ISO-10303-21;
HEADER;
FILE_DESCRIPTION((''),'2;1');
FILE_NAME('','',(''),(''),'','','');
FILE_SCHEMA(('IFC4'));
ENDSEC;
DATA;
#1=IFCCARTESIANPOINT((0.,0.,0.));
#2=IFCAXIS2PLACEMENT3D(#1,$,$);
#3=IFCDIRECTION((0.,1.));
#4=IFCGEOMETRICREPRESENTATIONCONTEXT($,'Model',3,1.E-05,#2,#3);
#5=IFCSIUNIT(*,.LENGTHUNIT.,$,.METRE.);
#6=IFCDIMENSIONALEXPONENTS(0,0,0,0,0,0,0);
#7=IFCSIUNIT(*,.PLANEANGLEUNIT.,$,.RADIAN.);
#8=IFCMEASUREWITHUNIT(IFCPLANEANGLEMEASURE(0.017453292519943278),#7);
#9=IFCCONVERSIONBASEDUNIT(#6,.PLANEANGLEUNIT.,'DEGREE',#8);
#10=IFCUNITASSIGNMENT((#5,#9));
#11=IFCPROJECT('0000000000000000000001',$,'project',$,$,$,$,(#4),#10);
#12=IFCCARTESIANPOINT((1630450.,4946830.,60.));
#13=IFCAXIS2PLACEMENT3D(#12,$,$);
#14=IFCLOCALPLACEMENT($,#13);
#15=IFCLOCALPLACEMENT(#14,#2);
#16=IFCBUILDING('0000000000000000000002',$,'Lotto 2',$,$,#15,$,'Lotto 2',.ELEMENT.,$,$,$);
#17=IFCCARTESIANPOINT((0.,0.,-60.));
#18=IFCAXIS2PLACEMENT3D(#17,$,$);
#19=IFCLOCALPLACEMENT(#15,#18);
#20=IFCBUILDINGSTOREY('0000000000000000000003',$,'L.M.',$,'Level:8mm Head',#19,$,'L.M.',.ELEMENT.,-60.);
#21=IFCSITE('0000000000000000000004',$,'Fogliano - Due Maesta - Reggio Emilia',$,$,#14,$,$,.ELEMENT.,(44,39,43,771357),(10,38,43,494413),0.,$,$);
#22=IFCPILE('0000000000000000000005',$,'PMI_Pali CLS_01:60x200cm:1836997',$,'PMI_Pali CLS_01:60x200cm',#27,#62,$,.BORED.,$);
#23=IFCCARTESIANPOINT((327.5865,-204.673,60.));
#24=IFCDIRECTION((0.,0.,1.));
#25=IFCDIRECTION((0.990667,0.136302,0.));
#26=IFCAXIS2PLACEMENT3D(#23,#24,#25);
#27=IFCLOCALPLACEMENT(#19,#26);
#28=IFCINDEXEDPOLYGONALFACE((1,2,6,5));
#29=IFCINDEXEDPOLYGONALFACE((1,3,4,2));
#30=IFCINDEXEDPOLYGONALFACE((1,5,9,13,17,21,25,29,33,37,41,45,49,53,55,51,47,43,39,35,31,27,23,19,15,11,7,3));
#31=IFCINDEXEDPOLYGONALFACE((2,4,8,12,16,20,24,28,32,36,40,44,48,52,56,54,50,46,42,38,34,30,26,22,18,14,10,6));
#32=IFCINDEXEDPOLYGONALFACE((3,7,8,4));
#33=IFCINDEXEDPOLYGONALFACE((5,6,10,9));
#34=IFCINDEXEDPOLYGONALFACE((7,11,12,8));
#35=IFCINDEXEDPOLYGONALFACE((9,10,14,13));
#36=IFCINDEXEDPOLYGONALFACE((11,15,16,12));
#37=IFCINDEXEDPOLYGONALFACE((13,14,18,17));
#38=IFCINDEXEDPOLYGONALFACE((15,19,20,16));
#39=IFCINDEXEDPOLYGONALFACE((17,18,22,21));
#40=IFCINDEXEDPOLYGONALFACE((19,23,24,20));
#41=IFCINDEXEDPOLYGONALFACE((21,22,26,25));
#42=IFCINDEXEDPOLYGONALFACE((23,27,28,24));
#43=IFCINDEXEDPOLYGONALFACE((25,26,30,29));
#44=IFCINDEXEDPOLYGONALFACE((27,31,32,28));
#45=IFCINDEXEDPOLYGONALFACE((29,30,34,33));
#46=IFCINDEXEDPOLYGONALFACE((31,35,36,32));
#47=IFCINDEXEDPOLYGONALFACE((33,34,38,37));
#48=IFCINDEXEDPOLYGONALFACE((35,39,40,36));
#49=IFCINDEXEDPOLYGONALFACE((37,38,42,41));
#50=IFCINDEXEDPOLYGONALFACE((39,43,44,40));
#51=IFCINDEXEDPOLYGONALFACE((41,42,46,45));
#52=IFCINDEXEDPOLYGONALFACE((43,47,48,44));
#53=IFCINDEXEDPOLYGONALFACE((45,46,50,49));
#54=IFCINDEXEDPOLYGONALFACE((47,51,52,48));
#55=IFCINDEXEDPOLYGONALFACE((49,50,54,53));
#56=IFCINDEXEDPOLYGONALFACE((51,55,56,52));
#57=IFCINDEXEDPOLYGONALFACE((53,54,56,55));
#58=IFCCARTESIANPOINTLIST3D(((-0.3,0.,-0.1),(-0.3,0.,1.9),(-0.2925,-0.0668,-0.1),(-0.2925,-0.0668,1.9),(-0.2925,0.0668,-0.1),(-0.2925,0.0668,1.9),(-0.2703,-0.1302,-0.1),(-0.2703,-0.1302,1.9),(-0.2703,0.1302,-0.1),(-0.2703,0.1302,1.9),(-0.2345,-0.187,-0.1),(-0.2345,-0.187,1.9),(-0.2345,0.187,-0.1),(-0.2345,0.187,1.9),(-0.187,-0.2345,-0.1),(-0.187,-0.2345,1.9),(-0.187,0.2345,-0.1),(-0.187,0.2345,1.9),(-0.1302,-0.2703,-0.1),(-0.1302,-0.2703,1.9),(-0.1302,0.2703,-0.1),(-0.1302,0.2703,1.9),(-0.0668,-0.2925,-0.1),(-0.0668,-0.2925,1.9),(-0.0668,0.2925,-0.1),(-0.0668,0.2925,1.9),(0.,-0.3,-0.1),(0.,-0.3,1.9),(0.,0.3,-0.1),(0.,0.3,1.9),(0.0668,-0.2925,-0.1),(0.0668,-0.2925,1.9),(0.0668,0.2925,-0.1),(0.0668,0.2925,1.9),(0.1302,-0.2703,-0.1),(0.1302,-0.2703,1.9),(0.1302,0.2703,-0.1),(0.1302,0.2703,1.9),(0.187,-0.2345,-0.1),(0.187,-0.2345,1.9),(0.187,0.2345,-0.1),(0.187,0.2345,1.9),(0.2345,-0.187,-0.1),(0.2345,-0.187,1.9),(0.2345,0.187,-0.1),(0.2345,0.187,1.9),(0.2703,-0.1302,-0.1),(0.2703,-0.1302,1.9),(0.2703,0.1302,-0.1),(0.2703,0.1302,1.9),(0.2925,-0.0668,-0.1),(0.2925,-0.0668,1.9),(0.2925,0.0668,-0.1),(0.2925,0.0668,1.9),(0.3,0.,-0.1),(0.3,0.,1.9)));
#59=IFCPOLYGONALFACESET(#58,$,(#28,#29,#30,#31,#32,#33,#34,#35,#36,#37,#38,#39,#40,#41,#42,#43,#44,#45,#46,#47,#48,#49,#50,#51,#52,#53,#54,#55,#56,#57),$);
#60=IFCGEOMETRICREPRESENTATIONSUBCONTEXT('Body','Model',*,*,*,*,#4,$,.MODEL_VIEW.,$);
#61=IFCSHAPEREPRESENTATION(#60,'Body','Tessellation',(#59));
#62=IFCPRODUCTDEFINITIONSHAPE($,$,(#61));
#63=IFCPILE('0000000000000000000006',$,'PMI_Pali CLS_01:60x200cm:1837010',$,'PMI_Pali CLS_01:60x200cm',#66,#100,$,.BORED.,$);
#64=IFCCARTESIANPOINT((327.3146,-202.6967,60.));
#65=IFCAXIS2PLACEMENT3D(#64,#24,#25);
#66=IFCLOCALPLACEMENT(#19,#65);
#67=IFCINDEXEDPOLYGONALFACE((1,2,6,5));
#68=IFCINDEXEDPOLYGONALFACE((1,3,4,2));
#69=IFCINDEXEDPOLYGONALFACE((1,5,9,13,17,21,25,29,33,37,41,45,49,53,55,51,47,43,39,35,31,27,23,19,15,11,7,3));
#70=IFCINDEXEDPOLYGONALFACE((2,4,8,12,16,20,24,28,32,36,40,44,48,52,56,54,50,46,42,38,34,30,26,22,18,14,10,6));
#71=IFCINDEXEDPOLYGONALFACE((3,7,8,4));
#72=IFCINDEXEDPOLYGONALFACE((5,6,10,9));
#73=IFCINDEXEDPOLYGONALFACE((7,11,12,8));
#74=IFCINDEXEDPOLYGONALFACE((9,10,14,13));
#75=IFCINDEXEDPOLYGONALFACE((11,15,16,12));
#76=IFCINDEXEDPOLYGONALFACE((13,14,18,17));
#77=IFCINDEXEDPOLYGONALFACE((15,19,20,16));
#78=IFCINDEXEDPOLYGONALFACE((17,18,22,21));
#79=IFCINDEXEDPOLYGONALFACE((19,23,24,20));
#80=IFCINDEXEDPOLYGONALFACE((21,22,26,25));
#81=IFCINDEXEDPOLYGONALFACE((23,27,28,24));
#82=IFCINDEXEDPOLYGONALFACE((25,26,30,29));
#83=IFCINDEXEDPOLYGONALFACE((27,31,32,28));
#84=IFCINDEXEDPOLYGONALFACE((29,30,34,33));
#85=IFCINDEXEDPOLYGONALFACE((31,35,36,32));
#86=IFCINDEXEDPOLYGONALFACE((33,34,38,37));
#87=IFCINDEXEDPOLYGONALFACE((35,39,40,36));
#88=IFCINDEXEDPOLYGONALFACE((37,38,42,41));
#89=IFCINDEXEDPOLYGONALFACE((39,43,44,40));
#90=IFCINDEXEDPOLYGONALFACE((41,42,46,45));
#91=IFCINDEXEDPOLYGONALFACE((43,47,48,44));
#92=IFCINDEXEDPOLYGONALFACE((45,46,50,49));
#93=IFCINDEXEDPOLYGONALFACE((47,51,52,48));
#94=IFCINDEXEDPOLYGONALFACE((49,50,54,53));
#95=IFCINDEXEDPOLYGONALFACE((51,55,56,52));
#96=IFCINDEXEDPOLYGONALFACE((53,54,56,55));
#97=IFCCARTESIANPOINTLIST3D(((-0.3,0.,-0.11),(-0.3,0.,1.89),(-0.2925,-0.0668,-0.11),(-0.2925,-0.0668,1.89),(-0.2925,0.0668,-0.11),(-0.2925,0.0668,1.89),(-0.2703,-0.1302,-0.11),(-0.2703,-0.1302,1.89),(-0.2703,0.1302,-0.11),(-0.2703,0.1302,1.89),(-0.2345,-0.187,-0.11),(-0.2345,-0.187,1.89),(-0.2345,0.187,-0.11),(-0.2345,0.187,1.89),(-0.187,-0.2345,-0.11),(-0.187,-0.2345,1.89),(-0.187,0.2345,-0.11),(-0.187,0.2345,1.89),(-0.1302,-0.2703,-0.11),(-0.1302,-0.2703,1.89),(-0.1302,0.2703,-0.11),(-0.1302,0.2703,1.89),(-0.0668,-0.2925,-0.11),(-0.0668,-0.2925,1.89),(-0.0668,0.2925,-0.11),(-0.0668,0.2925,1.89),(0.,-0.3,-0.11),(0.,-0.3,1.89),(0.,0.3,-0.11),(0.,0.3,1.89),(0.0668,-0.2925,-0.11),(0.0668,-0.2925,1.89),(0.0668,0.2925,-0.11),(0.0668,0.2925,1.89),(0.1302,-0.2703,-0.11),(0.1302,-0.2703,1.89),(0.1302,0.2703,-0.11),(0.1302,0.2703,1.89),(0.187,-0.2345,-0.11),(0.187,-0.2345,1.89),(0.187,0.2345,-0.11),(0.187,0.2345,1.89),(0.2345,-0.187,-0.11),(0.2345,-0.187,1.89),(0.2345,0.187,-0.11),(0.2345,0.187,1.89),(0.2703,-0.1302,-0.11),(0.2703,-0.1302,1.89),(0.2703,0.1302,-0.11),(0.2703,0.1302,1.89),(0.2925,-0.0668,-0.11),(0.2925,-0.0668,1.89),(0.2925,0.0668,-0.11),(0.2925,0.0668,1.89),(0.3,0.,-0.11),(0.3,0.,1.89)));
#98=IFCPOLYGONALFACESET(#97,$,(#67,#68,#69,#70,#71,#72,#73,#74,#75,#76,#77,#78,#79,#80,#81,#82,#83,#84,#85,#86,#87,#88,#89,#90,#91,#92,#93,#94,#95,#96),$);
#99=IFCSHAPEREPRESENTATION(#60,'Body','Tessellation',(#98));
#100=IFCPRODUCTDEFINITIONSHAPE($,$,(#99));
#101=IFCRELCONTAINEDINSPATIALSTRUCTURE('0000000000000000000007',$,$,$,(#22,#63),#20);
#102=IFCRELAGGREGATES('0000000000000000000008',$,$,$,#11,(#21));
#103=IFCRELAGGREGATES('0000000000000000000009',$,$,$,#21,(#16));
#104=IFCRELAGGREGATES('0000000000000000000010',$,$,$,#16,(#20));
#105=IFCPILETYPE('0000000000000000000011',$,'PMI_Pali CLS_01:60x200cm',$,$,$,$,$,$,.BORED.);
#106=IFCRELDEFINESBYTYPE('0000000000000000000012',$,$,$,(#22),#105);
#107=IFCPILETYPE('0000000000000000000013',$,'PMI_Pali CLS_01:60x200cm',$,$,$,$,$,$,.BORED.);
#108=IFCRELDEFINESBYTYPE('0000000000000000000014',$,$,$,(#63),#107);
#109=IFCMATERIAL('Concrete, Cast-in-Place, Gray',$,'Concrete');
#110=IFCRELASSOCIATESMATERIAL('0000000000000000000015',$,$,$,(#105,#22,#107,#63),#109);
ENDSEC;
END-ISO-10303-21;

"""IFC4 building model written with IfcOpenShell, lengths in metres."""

from ifc_helpers import new_model, entity, si_unit, converted_unit, direction, frame, origin, place, context, subcontext, project, spatial, arc, indexed_curve, outline, extrude, source, transform, mapped, material, type_object, type_shapes, element, save


model = new_model("IFC4")

# Units and contexts
model_context = context("Model", 3, precision=1e-05, world=origin(), true_north=direction((0.0, 1.0)))
body_context = subcontext(model_context, "Body", "Model", "MODEL_VIEW")
ifc_project = project(units=[si_unit("LENGTHUNIT", "METRE"), converted_unit("PLANEANGLEUNIT", "DEGREE", entity("IfcPlaneAngleMeasure", 0.017453292519943278), si_unit("PLANEANGLEUNIT", "RADIAN"), dimensions=[0, 0, 0, 0, 0, 0, 0])], contexts=[model_context])

# Site, building, storey
site_placement = place(None, frame((1630450.0, 4946830.0, 60.0)))
site = spatial("IfcSite", under=ifc_project, at=site_placement, Name="Fogliano - Due Maesta - Reggio Emilia", CompositionType="ELEMENT", RefLatitude=(44, 39, 43, 771357), RefLongitude=(10, 38, 43, 494413), RefElevation=0.0)
building_placement = place(site_placement, origin())
building = spatial("IfcBuilding", under=site, at=building_placement, Name="Lotto 2", LongName="Lotto 2", CompositionType="ELEMENT")
storey_placement = place(building_placement, frame((0.0, 0.0, -60.0)))
storey = spatial("IfcBuildingStorey", under=building, at=storey_placement, Name="L.M.", ObjectType="Level:8mm Head", LongName="L.M.", CompositionType="ELEMENT", Elevation=-60.0)

# Piles
ifc_material_1 = material(Name="Concrete, Cast-in-Place, Gray", Category="Concrete")
pile_type_1 = type_object("IfcPileType", Name="PMI_Pali CLS_01:60x200cm", PredefinedType="BORED", material=ifc_material_1)
shared_shape_1 = source(origin(), body_context, "Body", "SweptSolid", [
    extrude(outline(indexed_curve([(-0.3, 0.0), (0.0, -0.3), (0.3, 0.0), (0.0, 0.3)], segments=[arc(1, 2, 3), arc(3, 4, 1)], self_intersect=False)), frame((0.0, 0.0, -0.1)), (0.0, 0.0, 1.0), 2.0),
])
type_shapes(pile_type_1, [shared_shape_1])
pile_1_placement = place(storey_placement, frame((327.5865, -204.673, 60.0), z_axis=(0.0, 0.0, 1.0), x_axis=(0.990667, 0.136302, 0.0)))
element("IfcPile", 1, at=pile_1_placement, inside=storey, type_object=pile_type_1, material=ifc_material_1, Name="PMI_Pali CLS_01:60x200cm:1836997", ObjectType="PMI_Pali CLS_01:60x200cm", PredefinedType="BORED", context=body_context, shape_type="MappedRepresentation", body=[
    mapped(shared_shape_1, transform((0.0, 0.0, 0.0), scale=1.0)),
])
pile_type_2 = type_object("IfcPileType", Name="PMI_Pali CLS_01:60x200cm", PredefinedType="BORED", material=ifc_material_1)
shared_shape_2 = source(origin(), body_context, "Body", "SweptSolid", [
    extrude(outline(indexed_curve([(-0.3, 0.0), (0.0, -0.3), (0.3, 0.0), (0.0, 0.3)], segments=[arc(1, 2, 3), arc(3, 4, 1)], self_intersect=False)), frame((0.0, 0.0, -0.11)), (0.0, 0.0, 1.0), 2.0),
])
type_shapes(pile_type_2, [shared_shape_2])
pile_2_placement = place(storey_placement, frame((327.3146, -202.6967, 60.0), z_axis=(0.0, 0.0, 1.0), x_axis=(0.990667, 0.136302, 0.0)))
element("IfcPile", 2, at=pile_2_placement, inside=storey, type_object=pile_type_2, material=ifc_material_1, Name="PMI_Pali CLS_01:60x200cm:1837010", ObjectType="PMI_Pali CLS_01:60x200cm", PredefinedType="BORED", context=body_context, shape_type="MappedRepresentation", body=[
    mapped(shared_shape_2, transform((0.0, 0.0, 0.0), scale=1.0)),
])

save(model, "model.ifc")
